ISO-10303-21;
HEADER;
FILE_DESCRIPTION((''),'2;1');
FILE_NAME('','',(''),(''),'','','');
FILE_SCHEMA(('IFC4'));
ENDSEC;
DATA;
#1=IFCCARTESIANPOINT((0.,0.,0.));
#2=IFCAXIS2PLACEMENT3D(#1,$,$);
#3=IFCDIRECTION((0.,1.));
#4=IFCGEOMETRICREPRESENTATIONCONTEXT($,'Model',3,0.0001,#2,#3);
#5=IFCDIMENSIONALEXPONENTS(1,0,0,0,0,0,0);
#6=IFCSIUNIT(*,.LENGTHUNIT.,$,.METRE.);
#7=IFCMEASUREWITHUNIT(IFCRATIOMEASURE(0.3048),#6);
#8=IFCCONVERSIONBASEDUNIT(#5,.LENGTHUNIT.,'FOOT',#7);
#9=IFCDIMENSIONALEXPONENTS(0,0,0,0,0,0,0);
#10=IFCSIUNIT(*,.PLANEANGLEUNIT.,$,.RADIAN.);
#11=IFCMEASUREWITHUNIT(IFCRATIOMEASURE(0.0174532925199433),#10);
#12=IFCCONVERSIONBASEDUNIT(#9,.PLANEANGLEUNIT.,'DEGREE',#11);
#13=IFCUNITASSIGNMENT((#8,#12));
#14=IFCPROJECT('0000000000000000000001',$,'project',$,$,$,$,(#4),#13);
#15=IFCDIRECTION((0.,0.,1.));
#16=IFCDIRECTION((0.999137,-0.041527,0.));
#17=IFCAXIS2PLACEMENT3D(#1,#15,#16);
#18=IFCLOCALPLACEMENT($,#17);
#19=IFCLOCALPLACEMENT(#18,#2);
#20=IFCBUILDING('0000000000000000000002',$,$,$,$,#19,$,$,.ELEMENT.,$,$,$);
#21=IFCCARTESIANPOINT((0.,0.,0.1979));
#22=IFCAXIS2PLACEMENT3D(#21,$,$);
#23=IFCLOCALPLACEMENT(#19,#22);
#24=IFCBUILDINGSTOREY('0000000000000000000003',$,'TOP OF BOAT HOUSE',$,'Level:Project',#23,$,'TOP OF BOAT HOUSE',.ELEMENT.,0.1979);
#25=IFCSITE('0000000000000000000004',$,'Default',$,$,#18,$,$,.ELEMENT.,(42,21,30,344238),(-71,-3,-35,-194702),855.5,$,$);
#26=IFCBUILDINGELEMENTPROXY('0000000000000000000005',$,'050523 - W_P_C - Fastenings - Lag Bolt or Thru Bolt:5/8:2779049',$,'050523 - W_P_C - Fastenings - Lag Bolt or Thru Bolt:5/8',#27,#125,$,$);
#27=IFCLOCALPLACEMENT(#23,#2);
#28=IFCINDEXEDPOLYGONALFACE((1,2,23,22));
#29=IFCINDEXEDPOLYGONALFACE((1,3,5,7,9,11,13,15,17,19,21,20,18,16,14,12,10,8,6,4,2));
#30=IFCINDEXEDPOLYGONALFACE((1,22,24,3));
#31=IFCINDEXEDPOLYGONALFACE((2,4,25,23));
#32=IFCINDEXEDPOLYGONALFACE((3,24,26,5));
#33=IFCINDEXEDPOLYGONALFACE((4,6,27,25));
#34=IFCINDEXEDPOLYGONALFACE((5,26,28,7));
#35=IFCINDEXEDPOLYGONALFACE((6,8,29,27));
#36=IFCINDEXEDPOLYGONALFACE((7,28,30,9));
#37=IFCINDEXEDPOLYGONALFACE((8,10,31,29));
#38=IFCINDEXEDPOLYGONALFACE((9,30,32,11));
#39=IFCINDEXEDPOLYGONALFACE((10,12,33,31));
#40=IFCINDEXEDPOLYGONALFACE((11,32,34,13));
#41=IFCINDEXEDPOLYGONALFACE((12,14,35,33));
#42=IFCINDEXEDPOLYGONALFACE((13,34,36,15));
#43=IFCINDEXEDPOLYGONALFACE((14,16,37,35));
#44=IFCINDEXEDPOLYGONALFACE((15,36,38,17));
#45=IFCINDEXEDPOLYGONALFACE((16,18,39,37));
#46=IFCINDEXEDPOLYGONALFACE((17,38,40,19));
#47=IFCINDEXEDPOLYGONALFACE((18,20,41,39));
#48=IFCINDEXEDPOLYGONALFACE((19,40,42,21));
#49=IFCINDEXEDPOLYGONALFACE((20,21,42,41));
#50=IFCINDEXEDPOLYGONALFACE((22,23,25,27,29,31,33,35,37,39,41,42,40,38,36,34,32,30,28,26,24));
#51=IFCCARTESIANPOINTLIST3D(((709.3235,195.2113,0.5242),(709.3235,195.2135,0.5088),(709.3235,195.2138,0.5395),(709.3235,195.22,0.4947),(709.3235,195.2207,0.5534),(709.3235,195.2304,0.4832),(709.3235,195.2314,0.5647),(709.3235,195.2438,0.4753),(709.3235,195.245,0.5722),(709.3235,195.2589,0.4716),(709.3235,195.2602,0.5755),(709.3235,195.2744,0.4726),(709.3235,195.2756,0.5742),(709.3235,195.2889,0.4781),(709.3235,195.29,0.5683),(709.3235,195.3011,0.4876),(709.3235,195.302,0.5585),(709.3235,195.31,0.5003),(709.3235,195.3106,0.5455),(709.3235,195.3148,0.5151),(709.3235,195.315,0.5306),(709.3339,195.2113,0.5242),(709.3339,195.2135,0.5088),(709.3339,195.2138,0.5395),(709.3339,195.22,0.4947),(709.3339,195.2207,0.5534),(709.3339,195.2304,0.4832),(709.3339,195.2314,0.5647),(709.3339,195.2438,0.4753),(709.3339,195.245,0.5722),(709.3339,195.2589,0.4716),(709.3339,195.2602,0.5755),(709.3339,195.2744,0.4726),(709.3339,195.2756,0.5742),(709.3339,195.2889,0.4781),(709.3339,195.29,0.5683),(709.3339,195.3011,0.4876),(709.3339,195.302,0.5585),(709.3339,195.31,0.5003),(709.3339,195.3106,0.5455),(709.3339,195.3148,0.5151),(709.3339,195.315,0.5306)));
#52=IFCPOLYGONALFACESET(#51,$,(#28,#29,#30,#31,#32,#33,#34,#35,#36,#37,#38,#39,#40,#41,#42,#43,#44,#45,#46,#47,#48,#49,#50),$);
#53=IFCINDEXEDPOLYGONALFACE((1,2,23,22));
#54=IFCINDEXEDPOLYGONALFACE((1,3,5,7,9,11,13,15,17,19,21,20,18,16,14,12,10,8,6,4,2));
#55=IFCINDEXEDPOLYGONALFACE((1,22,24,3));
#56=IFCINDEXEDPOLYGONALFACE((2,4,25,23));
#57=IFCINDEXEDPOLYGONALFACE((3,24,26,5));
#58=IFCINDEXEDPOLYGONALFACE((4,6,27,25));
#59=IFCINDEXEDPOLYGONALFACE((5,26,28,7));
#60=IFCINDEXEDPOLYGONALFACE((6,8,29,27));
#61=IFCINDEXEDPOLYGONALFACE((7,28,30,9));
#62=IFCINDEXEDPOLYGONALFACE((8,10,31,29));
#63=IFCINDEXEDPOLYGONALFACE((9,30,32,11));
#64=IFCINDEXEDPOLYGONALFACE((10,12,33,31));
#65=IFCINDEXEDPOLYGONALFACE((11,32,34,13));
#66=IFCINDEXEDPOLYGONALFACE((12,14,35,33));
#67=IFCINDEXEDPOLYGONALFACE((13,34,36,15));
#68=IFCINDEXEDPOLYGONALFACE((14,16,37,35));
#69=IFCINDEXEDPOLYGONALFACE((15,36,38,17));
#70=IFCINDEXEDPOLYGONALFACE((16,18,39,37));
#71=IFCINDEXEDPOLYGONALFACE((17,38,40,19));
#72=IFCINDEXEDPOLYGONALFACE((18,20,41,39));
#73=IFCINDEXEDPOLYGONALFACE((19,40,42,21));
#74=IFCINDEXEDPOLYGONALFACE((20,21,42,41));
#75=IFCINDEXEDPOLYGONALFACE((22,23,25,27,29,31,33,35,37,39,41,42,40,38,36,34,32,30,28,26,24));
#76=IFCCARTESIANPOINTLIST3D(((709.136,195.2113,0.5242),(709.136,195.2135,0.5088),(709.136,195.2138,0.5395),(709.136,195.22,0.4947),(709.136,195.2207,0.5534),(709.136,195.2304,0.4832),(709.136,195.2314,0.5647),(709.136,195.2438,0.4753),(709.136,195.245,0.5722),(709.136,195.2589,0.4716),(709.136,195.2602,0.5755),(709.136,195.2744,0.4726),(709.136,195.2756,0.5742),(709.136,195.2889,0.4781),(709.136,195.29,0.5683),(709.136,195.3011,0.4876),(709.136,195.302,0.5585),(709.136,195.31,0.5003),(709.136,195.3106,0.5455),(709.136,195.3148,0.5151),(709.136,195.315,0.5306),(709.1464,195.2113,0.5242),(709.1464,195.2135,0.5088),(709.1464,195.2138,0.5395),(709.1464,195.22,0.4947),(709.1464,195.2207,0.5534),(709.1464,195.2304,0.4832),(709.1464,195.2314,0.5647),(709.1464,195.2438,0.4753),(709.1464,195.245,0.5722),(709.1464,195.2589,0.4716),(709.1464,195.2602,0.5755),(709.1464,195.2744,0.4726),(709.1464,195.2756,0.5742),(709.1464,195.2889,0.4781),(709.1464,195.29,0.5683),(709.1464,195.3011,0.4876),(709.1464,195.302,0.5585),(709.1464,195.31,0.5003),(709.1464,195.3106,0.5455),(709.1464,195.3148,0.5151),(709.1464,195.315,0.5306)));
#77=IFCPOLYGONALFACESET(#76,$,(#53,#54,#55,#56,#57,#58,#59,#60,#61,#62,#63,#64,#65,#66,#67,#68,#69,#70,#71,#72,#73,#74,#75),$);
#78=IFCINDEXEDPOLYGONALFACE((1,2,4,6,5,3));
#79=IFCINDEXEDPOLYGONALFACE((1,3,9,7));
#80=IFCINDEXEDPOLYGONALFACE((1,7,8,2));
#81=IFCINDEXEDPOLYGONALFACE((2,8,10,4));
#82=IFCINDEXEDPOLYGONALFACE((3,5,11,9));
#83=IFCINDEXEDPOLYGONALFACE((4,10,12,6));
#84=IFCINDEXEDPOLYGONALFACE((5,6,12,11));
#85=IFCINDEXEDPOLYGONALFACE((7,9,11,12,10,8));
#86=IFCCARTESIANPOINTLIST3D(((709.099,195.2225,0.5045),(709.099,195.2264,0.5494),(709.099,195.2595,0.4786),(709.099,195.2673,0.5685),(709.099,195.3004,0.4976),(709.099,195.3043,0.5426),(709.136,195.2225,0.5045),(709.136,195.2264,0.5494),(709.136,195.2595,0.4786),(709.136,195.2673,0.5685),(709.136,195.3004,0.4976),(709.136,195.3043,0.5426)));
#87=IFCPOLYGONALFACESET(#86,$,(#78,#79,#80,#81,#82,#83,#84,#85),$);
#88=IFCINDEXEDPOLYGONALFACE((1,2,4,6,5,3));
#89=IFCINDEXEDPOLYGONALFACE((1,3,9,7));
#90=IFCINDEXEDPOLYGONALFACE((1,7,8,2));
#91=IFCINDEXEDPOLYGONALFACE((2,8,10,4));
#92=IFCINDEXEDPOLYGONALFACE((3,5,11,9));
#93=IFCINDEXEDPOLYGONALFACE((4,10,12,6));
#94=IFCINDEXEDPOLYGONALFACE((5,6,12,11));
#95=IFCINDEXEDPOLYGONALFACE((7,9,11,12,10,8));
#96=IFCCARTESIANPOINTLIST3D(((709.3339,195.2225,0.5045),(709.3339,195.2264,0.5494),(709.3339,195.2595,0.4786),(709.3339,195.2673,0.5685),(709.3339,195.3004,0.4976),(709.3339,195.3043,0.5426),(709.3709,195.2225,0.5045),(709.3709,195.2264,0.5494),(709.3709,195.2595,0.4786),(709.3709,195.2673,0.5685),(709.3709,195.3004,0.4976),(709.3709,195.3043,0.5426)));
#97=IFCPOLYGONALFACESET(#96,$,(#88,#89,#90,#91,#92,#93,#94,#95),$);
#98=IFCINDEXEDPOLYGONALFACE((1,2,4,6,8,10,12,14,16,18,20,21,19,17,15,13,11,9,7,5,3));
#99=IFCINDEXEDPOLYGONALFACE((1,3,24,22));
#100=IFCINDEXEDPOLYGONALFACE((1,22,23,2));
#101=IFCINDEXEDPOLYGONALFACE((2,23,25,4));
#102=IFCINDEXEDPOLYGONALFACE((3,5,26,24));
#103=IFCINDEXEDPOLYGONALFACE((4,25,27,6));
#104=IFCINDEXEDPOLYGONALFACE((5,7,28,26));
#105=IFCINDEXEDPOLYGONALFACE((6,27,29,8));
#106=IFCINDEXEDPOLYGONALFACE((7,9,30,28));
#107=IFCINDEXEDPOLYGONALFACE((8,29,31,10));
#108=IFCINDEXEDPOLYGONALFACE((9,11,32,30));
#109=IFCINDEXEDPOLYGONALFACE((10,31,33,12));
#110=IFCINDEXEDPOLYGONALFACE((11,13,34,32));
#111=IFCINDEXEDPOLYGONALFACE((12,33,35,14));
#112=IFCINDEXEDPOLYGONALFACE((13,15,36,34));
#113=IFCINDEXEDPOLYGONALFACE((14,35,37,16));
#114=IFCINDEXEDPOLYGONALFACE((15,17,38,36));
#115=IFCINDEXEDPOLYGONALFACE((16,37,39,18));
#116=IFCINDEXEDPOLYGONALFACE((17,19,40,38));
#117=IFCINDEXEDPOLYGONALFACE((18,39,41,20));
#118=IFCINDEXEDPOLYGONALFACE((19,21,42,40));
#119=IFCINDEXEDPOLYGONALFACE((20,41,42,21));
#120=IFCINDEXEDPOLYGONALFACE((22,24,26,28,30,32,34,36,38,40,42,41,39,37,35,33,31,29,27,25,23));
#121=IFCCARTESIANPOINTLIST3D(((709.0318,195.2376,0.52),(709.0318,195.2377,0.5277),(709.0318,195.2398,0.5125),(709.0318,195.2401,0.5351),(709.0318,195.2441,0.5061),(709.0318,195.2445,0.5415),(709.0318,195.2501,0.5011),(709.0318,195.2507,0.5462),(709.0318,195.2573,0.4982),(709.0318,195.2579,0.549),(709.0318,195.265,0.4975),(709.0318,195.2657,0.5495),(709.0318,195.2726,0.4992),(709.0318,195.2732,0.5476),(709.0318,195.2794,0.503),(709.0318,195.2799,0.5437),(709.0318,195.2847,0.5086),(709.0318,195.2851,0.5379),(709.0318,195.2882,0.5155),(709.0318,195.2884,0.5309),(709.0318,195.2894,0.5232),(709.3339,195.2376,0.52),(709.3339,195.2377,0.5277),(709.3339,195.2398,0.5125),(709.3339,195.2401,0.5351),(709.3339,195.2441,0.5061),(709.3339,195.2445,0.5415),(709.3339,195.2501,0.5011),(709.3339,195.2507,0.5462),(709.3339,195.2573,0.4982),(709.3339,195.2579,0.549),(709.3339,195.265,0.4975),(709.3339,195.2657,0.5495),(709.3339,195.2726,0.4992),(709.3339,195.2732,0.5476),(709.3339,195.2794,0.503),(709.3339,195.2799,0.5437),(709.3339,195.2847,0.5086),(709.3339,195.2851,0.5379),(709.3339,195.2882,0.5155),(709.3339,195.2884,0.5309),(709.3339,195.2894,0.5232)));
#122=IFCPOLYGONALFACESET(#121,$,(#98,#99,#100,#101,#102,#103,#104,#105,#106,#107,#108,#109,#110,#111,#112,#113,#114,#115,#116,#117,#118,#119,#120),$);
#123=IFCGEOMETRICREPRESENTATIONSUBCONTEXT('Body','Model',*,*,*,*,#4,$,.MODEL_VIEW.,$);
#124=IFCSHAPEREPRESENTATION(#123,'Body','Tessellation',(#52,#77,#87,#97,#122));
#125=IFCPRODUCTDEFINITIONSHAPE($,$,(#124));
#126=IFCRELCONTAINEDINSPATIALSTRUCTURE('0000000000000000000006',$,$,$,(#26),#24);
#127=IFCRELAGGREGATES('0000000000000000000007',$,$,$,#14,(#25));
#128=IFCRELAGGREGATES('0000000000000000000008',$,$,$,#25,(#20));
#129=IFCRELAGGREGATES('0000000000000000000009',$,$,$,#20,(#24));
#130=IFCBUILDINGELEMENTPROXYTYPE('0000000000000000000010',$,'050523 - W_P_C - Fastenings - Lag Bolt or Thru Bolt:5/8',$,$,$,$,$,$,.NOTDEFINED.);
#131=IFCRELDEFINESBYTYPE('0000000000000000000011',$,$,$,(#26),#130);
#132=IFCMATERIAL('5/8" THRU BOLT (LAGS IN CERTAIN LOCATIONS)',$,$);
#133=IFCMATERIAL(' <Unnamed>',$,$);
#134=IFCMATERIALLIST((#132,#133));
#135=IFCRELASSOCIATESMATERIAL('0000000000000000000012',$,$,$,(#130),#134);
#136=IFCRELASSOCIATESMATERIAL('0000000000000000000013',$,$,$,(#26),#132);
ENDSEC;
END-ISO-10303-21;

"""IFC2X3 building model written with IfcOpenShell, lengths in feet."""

from ifc_helpers import new_model, entity, si_unit, converted_unit, direction, frame, frame_2d, origin, place, context, subcontext, project, spatial, polyline, circle, outline, extrude, source, transform, mapped, material, material_list, type_object, type_shapes, element, save


model = new_model("IFC2X3")

# Units and contexts
model_context = context("Model", 3, precision=0.0001, world=origin(), true_north=direction((0.0, 1.0)))
body_context = subcontext(model_context, "Body", "Model", "MODEL_VIEW")
ifc_project = project(units=[converted_unit("LENGTHUNIT", "FOOT", entity("IfcRatioMeasure", 0.3048), si_unit("LENGTHUNIT", "METRE"), dimensions=[1, 0, 0, 0, 0, 0, 0]), converted_unit("PLANEANGLEUNIT", "DEGREE", entity("IfcRatioMeasure", 0.0174532925199433), si_unit("PLANEANGLEUNIT", "RADIAN"), dimensions=[0, 0, 0, 0, 0, 0, 0])], contexts=[model_context])

# Site, building, storey
site_placement = place(None, frame((0.0, 0.0, 0.0), z_axis=(0.0, 0.0, 1.0), x_axis=(0.999137, -0.041527, 0.0)))
site = spatial("IfcSite", under=ifc_project, at=site_placement, Name="Default", CompositionType="ELEMENT", RefLatitude=(42, 21, 30, 344238), RefLongitude=(-71, -3, -35, -194702), RefElevation=855.5)
building_placement = place(site_placement, origin())
building = spatial("IfcBuilding", under=site, at=building_placement, CompositionType="ELEMENT")
storey_placement = place(building_placement, frame((0.0, 0.0, 0.1979)))
storey = spatial("IfcBuildingStorey", under=building, at=storey_placement, Name="TOP OF BOAT HOUSE", ObjectType="Level:Project", LongName="TOP OF BOAT HOUSE", CompositionType="ELEMENT", Elevation=0.1979)

# Building element proxy
ifc_material_1 = material(Name="5/8\" THRU BOLT (LAGS IN CERTAIN LOCATIONS)")
ifc_material_2 = material(Name=" <Unnamed>")
ifc_material_list_1 = material_list([ifc_material_1, ifc_material_2])
building_element_proxy_type_1 = type_object("IfcBuildingElementProxyType", Name="050523 - W_P_C - Fastenings - Lag Bolt or Thru Bolt:5/8", PredefinedType="NOTDEFINED", material=ifc_material_list_1)
shared_shape_1 = source(origin(), body_context, "Body", "SweptSolid", [
    extrude(circle(Radius=0.0521, at=frame_2d((0.0, 0.0), x_axis=(1.0, 0.0))), frame((0.0, 0.0, 0.0), z_axis=(0.0, 0.0, 1.0), x_axis=(0.0, -1.0, 0.0)), (0.0, 0.0, 1.0), 0.0104),
    extrude(circle(Radius=0.0521, at=frame_2d((0.0, 0.0), x_axis=(1.0, 0.0))), frame((0.0, 0.0, -0.1875), z_axis=(0.0, 0.0, 1.0), x_axis=(0.0, -1.0, 0.0)), (0.0, 0.0, 1.0), 0.0104),
    extrude(outline(polyline([(-0.0226, -0.0391), (0.0226, -0.0391), (0.0451, 0.0), (0.0226, 0.0391), (-0.0226, 0.0391), (-0.0451, 0.0), (-0.0226, -0.0391)])), frame((0.0, 0.0, -0.2245), z_axis=(0.0, 0.0, 1.0), x_axis=(0.866025, -0.5, 0.0)), (0.0, 0.0, 1.0), 0.037),
    extrude(outline(polyline([(-0.0226, -0.0391), (0.0226, -0.0391), (0.0451, 0.0), (0.0226, 0.0391), (-0.0226, 0.0391), (-0.0451, 0.0), (-0.0226, -0.0391)])), frame((0.0, 0.0, 0.0104), z_axis=(0.0, 0.0, 1.0), x_axis=(0.0, -1.0, 0.0)), (0.0, 0.0, 1.0), 0.037),
    extrude(circle(Radius=0.026, at=frame_2d((0.0, 0.0), x_axis=(1.0, 0.0))), frame((0.0, 0.0, -0.2917), z_axis=(0.0, 0.0, 1.0), x_axis=(0.0, 1.0, 0.0)), (0.0, 0.0, 1.0), 0.3021),
])
type_shapes(building_element_proxy_type_1, [shared_shape_1])
for number, where, z_axis, x_axis, name in (
    (1, (709.3235, 195.2634, 0.5235), (1.0, 0.0, 0.0), (0.0, 0.996195, -0.087156), "050523 - W_P_C - Fastenings - Lag Bolt or Thru Bolt:5/8:2779049"),
):
    element("IfcBuildingElementProxy", number, at=place(storey_placement, frame(where, z_axis=z_axis, x_axis=x_axis)), inside=storey, type_object=building_element_proxy_type_1, material=ifc_material_1, Name=name, ObjectType="050523 - W_P_C - Fastenings - Lag Bolt or Thru Bolt:5/8", context=body_context, shape_type="MappedRepresentation", body=[
        mapped(shared_shape_1, transform((0.0, 0.0, 0.0), scale=1.0)),
    ])

save(model, "model.ifc")
